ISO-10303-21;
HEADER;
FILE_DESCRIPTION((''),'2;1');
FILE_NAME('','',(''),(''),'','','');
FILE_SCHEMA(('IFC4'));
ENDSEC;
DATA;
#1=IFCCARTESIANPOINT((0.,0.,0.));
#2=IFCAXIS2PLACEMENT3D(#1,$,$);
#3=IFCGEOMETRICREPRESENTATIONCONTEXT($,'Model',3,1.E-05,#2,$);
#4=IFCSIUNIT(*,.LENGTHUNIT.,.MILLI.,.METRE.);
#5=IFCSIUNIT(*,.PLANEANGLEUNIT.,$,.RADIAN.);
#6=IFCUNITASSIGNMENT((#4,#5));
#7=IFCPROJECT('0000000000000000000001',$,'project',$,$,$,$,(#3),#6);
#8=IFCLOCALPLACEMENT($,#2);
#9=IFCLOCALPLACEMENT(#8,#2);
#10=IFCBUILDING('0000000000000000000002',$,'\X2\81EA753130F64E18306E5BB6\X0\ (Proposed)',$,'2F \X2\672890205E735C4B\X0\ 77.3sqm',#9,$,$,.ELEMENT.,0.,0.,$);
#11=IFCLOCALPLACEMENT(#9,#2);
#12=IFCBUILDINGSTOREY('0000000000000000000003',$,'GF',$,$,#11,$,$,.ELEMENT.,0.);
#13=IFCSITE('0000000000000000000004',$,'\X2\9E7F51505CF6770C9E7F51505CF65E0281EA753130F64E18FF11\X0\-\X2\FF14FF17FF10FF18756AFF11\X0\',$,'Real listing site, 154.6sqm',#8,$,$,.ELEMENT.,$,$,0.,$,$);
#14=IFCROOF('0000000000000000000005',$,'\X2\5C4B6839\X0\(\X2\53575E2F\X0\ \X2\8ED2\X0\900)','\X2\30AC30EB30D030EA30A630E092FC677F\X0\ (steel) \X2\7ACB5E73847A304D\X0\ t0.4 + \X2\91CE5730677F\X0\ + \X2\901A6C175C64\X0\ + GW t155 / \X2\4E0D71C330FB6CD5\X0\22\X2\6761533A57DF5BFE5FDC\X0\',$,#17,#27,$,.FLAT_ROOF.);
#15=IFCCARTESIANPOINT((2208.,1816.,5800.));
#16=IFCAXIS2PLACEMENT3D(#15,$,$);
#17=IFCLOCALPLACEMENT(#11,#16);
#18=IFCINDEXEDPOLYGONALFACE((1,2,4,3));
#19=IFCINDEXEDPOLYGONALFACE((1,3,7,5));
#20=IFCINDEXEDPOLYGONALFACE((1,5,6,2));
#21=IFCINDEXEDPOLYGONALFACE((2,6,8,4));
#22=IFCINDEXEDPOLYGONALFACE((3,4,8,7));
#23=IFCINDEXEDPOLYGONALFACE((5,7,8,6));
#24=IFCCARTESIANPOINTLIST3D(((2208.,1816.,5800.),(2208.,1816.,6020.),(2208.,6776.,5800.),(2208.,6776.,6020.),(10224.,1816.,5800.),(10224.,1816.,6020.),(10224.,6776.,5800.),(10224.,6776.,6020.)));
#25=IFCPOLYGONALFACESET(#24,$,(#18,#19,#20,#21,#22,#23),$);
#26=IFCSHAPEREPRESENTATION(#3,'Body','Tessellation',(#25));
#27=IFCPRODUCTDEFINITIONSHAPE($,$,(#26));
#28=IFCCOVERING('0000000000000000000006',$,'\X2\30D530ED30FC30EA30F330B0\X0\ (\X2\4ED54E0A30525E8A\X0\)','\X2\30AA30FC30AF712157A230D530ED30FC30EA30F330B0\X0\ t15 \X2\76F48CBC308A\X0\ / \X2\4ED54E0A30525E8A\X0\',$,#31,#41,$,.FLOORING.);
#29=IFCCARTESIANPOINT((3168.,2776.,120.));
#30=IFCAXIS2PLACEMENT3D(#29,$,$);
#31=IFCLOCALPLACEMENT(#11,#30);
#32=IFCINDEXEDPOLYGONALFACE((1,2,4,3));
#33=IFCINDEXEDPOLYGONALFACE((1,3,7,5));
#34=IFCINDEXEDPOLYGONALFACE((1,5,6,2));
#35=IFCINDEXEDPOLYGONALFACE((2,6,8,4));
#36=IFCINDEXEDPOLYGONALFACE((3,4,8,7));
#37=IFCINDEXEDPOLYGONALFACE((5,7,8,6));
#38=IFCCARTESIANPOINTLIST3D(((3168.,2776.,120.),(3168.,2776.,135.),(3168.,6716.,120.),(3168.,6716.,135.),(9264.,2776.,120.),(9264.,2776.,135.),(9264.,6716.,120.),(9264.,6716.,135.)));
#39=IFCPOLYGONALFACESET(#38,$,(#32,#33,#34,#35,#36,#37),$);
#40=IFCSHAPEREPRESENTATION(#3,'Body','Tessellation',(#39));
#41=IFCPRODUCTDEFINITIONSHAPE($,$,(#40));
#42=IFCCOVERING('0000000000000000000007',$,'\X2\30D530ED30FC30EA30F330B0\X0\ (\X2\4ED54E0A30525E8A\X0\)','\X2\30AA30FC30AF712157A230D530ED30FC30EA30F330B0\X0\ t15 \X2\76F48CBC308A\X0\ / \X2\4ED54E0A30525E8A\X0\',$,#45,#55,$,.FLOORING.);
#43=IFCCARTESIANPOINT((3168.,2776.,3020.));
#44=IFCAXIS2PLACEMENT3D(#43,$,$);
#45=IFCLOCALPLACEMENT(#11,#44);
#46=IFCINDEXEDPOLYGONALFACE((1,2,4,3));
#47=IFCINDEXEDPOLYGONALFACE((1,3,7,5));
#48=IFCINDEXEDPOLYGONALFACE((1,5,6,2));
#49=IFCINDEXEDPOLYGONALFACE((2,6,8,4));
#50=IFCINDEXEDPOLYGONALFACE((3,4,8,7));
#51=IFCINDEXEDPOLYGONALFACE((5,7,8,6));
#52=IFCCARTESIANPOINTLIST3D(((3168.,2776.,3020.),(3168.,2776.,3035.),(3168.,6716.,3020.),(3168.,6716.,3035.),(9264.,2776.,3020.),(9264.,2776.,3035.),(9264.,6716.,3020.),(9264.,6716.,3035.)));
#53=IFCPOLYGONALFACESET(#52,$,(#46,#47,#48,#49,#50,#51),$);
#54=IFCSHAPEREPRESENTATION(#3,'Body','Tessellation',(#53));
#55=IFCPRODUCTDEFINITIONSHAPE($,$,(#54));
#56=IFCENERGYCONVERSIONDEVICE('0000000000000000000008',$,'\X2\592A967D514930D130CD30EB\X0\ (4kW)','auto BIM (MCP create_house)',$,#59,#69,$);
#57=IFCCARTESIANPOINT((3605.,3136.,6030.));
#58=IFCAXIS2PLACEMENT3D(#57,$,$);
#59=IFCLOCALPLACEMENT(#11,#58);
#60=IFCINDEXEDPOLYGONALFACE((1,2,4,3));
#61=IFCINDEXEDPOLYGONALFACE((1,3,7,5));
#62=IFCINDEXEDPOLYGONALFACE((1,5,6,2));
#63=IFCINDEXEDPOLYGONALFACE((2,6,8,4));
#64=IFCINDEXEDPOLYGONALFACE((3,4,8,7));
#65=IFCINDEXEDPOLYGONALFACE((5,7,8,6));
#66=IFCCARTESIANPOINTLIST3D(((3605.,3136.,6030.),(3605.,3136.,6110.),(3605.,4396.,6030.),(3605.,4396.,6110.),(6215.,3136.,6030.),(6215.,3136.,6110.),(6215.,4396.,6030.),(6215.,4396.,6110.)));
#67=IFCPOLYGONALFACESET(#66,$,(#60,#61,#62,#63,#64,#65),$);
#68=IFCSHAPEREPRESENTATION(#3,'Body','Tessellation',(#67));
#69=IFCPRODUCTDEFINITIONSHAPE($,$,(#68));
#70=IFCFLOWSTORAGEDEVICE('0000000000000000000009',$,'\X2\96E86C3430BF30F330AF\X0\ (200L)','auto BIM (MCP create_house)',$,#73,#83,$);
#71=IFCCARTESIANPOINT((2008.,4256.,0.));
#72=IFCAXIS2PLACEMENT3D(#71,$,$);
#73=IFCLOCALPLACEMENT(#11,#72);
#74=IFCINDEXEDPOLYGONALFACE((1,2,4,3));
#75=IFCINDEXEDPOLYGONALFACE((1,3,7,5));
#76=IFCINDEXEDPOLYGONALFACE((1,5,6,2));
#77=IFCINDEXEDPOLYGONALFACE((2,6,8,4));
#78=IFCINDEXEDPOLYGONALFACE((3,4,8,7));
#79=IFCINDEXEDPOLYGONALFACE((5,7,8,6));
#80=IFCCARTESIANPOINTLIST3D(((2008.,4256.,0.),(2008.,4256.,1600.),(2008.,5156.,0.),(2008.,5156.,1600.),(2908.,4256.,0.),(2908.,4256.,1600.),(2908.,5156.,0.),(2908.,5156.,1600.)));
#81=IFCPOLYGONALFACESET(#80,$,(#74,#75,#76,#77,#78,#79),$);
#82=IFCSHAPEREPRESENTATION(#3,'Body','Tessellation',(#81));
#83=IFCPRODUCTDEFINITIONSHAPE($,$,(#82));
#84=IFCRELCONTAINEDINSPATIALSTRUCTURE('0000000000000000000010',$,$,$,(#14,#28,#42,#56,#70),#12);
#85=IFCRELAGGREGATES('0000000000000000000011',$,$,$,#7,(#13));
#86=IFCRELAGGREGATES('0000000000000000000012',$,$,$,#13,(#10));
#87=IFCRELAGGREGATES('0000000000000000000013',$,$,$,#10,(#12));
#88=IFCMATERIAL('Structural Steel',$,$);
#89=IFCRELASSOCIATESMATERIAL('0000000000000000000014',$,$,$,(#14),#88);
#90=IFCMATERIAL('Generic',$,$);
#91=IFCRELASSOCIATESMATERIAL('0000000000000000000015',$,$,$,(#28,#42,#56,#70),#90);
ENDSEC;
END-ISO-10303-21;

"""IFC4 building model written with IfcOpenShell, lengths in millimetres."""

from ifc_helpers import new_model, si_unit, frame, frame_2d, origin, place, context, project, spatial, rectangle, extrude, material, element, save


model = new_model("IFC4")

# Units and contexts
model_context = context("Model", 3, precision=1e-05, world=origin())
ifc_project = project(units=[si_unit("LENGTHUNIT", "METRE", prefix="MILLI"), si_unit("PLANEANGLEUNIT", "RADIAN")], contexts=[model_context])

# Site, building, storey
site_placement = place(None, origin())
site = spatial("IfcSite", under=ifc_project, at=site_placement, Name="鹿児島県鹿児島市自由ヶ丘１-４７０８番１", ObjectType="Real listing site, 154.6sqm", CompositionType="ELEMENT", RefElevation=0.0)
building_placement = place(site_placement, origin())
building = spatial("IfcBuilding", under=site, at=building_placement, Name="自由ヶ丘の家 (Proposed)", ObjectType="2F 木造平屋 77.3sqm", CompositionType="ELEMENT", ElevationOfRefHeight=0.0, ElevationOfTerrain=0.0)
storey_placement = place(building_placement, origin())
storey = spatial("IfcBuildingStorey", under=building, at=storey_placement, Name="GF", CompositionType="ELEMENT", Elevation=0.0)

# Roof
ifc_material_1 = material(Name="Structural Steel")
for number, where, name in (
    (1, (2208.0, 1816.0, 5800.0), "屋根(南帯 軒900)"),
):
    element("IfcRoof", number, at=place(storey_placement, frame(where)), inside=storey, material=ifc_material_1, Name=name, Description="ガルバリウム鋼板 (steel) 立平葺き t0.4 + 野地板 + 通気層 + GW t155 / 不燃・法22条区域対応", PredefinedType="FLAT_ROOF", context=model_context, shape_type="SweptSolid", body=[
        extrude(rectangle(XDim=8016.0, YDim=4960.0, at=frame_2d((4008.0, 2480.0))), frame((2208.0, 1816.0, 5800.0)), (0.0, 0.0, 1.0), 220.0),
    ])

# Coverings
ifc_material_2 = material(Name="Generic")
covering_1_placement = place(storey_placement, frame((3168.0, 2776.0, 120.0)))
element("IfcCovering", 2, at=covering_1_placement, inside=storey, material=ifc_material_2, Name="フローリング (仕上げ床)", Description="オーク無垢フローリング t15 直貼り / 仕上げ床", PredefinedType="FLOORING", context=model_context, shape_type="SweptSolid", body=[
    extrude(rectangle(XDim=6096.0, YDim=3940.0, at=frame_2d((3048.0, 1970.0))), frame((3168.0, 2776.0, 120.0)), (0.0, 0.0, 1.0), 15.0),
])
covering_2_placement = place(storey_placement, frame((3168.0, 2776.0, 3020.0)))
element("IfcCovering", 3, at=covering_2_placement, inside=storey, material=ifc_material_2, Name="フローリング (仕上げ床)", Description="オーク無垢フローリング t15 直貼り / 仕上げ床", PredefinedType="FLOORING", context=model_context, shape_type="SweptSolid", body=[
    extrude(rectangle(XDim=6096.0, YDim=3940.0, at=frame_2d((3048.0, 1970.0))), frame((3168.0, 2776.0, 3020.0)), (0.0, 0.0, 1.0), 15.0),
])

# Energy conversion device
energy_conversion_device_placement = place(storey_placement, frame((3605.0, 3136.0, 6030.0)))
element("IfcEnergyConversionDevice", 4, at=energy_conversion_device_placement, inside=storey, material=ifc_material_2, Name="太陽光パネル (4kW)", Description="auto BIM (MCP create_house)", context=model_context, shape_type="SweptSolid", body=[
    extrude(rectangle(XDim=2610.0, YDim=1260.0, at=frame_2d((1305.0, 630.0))), frame((3605.0, 3136.0, 6030.0)), (0.0, 0.0, 1.0), 80.0),
])

# Flow storage device
flow_storage_device_placement = place(storey_placement, frame((2008.0, 4256.0, 0.0)))
element("IfcFlowStorageDevice", 5, at=flow_storage_device_placement, inside=storey, material=ifc_material_2, Name="雨水タンク (200L)", Description="auto BIM (MCP create_house)", context=model_context, shape_type="SweptSolid", body=[
    extrude(rectangle(XDim=900.0, YDim=900.0, at=frame_2d((450.0, 450.0))), frame((2008.0, 4256.0, 0.0)), (0.0, 0.0, 1.0), 1600.0),
])

save(model, "model.ifc")
